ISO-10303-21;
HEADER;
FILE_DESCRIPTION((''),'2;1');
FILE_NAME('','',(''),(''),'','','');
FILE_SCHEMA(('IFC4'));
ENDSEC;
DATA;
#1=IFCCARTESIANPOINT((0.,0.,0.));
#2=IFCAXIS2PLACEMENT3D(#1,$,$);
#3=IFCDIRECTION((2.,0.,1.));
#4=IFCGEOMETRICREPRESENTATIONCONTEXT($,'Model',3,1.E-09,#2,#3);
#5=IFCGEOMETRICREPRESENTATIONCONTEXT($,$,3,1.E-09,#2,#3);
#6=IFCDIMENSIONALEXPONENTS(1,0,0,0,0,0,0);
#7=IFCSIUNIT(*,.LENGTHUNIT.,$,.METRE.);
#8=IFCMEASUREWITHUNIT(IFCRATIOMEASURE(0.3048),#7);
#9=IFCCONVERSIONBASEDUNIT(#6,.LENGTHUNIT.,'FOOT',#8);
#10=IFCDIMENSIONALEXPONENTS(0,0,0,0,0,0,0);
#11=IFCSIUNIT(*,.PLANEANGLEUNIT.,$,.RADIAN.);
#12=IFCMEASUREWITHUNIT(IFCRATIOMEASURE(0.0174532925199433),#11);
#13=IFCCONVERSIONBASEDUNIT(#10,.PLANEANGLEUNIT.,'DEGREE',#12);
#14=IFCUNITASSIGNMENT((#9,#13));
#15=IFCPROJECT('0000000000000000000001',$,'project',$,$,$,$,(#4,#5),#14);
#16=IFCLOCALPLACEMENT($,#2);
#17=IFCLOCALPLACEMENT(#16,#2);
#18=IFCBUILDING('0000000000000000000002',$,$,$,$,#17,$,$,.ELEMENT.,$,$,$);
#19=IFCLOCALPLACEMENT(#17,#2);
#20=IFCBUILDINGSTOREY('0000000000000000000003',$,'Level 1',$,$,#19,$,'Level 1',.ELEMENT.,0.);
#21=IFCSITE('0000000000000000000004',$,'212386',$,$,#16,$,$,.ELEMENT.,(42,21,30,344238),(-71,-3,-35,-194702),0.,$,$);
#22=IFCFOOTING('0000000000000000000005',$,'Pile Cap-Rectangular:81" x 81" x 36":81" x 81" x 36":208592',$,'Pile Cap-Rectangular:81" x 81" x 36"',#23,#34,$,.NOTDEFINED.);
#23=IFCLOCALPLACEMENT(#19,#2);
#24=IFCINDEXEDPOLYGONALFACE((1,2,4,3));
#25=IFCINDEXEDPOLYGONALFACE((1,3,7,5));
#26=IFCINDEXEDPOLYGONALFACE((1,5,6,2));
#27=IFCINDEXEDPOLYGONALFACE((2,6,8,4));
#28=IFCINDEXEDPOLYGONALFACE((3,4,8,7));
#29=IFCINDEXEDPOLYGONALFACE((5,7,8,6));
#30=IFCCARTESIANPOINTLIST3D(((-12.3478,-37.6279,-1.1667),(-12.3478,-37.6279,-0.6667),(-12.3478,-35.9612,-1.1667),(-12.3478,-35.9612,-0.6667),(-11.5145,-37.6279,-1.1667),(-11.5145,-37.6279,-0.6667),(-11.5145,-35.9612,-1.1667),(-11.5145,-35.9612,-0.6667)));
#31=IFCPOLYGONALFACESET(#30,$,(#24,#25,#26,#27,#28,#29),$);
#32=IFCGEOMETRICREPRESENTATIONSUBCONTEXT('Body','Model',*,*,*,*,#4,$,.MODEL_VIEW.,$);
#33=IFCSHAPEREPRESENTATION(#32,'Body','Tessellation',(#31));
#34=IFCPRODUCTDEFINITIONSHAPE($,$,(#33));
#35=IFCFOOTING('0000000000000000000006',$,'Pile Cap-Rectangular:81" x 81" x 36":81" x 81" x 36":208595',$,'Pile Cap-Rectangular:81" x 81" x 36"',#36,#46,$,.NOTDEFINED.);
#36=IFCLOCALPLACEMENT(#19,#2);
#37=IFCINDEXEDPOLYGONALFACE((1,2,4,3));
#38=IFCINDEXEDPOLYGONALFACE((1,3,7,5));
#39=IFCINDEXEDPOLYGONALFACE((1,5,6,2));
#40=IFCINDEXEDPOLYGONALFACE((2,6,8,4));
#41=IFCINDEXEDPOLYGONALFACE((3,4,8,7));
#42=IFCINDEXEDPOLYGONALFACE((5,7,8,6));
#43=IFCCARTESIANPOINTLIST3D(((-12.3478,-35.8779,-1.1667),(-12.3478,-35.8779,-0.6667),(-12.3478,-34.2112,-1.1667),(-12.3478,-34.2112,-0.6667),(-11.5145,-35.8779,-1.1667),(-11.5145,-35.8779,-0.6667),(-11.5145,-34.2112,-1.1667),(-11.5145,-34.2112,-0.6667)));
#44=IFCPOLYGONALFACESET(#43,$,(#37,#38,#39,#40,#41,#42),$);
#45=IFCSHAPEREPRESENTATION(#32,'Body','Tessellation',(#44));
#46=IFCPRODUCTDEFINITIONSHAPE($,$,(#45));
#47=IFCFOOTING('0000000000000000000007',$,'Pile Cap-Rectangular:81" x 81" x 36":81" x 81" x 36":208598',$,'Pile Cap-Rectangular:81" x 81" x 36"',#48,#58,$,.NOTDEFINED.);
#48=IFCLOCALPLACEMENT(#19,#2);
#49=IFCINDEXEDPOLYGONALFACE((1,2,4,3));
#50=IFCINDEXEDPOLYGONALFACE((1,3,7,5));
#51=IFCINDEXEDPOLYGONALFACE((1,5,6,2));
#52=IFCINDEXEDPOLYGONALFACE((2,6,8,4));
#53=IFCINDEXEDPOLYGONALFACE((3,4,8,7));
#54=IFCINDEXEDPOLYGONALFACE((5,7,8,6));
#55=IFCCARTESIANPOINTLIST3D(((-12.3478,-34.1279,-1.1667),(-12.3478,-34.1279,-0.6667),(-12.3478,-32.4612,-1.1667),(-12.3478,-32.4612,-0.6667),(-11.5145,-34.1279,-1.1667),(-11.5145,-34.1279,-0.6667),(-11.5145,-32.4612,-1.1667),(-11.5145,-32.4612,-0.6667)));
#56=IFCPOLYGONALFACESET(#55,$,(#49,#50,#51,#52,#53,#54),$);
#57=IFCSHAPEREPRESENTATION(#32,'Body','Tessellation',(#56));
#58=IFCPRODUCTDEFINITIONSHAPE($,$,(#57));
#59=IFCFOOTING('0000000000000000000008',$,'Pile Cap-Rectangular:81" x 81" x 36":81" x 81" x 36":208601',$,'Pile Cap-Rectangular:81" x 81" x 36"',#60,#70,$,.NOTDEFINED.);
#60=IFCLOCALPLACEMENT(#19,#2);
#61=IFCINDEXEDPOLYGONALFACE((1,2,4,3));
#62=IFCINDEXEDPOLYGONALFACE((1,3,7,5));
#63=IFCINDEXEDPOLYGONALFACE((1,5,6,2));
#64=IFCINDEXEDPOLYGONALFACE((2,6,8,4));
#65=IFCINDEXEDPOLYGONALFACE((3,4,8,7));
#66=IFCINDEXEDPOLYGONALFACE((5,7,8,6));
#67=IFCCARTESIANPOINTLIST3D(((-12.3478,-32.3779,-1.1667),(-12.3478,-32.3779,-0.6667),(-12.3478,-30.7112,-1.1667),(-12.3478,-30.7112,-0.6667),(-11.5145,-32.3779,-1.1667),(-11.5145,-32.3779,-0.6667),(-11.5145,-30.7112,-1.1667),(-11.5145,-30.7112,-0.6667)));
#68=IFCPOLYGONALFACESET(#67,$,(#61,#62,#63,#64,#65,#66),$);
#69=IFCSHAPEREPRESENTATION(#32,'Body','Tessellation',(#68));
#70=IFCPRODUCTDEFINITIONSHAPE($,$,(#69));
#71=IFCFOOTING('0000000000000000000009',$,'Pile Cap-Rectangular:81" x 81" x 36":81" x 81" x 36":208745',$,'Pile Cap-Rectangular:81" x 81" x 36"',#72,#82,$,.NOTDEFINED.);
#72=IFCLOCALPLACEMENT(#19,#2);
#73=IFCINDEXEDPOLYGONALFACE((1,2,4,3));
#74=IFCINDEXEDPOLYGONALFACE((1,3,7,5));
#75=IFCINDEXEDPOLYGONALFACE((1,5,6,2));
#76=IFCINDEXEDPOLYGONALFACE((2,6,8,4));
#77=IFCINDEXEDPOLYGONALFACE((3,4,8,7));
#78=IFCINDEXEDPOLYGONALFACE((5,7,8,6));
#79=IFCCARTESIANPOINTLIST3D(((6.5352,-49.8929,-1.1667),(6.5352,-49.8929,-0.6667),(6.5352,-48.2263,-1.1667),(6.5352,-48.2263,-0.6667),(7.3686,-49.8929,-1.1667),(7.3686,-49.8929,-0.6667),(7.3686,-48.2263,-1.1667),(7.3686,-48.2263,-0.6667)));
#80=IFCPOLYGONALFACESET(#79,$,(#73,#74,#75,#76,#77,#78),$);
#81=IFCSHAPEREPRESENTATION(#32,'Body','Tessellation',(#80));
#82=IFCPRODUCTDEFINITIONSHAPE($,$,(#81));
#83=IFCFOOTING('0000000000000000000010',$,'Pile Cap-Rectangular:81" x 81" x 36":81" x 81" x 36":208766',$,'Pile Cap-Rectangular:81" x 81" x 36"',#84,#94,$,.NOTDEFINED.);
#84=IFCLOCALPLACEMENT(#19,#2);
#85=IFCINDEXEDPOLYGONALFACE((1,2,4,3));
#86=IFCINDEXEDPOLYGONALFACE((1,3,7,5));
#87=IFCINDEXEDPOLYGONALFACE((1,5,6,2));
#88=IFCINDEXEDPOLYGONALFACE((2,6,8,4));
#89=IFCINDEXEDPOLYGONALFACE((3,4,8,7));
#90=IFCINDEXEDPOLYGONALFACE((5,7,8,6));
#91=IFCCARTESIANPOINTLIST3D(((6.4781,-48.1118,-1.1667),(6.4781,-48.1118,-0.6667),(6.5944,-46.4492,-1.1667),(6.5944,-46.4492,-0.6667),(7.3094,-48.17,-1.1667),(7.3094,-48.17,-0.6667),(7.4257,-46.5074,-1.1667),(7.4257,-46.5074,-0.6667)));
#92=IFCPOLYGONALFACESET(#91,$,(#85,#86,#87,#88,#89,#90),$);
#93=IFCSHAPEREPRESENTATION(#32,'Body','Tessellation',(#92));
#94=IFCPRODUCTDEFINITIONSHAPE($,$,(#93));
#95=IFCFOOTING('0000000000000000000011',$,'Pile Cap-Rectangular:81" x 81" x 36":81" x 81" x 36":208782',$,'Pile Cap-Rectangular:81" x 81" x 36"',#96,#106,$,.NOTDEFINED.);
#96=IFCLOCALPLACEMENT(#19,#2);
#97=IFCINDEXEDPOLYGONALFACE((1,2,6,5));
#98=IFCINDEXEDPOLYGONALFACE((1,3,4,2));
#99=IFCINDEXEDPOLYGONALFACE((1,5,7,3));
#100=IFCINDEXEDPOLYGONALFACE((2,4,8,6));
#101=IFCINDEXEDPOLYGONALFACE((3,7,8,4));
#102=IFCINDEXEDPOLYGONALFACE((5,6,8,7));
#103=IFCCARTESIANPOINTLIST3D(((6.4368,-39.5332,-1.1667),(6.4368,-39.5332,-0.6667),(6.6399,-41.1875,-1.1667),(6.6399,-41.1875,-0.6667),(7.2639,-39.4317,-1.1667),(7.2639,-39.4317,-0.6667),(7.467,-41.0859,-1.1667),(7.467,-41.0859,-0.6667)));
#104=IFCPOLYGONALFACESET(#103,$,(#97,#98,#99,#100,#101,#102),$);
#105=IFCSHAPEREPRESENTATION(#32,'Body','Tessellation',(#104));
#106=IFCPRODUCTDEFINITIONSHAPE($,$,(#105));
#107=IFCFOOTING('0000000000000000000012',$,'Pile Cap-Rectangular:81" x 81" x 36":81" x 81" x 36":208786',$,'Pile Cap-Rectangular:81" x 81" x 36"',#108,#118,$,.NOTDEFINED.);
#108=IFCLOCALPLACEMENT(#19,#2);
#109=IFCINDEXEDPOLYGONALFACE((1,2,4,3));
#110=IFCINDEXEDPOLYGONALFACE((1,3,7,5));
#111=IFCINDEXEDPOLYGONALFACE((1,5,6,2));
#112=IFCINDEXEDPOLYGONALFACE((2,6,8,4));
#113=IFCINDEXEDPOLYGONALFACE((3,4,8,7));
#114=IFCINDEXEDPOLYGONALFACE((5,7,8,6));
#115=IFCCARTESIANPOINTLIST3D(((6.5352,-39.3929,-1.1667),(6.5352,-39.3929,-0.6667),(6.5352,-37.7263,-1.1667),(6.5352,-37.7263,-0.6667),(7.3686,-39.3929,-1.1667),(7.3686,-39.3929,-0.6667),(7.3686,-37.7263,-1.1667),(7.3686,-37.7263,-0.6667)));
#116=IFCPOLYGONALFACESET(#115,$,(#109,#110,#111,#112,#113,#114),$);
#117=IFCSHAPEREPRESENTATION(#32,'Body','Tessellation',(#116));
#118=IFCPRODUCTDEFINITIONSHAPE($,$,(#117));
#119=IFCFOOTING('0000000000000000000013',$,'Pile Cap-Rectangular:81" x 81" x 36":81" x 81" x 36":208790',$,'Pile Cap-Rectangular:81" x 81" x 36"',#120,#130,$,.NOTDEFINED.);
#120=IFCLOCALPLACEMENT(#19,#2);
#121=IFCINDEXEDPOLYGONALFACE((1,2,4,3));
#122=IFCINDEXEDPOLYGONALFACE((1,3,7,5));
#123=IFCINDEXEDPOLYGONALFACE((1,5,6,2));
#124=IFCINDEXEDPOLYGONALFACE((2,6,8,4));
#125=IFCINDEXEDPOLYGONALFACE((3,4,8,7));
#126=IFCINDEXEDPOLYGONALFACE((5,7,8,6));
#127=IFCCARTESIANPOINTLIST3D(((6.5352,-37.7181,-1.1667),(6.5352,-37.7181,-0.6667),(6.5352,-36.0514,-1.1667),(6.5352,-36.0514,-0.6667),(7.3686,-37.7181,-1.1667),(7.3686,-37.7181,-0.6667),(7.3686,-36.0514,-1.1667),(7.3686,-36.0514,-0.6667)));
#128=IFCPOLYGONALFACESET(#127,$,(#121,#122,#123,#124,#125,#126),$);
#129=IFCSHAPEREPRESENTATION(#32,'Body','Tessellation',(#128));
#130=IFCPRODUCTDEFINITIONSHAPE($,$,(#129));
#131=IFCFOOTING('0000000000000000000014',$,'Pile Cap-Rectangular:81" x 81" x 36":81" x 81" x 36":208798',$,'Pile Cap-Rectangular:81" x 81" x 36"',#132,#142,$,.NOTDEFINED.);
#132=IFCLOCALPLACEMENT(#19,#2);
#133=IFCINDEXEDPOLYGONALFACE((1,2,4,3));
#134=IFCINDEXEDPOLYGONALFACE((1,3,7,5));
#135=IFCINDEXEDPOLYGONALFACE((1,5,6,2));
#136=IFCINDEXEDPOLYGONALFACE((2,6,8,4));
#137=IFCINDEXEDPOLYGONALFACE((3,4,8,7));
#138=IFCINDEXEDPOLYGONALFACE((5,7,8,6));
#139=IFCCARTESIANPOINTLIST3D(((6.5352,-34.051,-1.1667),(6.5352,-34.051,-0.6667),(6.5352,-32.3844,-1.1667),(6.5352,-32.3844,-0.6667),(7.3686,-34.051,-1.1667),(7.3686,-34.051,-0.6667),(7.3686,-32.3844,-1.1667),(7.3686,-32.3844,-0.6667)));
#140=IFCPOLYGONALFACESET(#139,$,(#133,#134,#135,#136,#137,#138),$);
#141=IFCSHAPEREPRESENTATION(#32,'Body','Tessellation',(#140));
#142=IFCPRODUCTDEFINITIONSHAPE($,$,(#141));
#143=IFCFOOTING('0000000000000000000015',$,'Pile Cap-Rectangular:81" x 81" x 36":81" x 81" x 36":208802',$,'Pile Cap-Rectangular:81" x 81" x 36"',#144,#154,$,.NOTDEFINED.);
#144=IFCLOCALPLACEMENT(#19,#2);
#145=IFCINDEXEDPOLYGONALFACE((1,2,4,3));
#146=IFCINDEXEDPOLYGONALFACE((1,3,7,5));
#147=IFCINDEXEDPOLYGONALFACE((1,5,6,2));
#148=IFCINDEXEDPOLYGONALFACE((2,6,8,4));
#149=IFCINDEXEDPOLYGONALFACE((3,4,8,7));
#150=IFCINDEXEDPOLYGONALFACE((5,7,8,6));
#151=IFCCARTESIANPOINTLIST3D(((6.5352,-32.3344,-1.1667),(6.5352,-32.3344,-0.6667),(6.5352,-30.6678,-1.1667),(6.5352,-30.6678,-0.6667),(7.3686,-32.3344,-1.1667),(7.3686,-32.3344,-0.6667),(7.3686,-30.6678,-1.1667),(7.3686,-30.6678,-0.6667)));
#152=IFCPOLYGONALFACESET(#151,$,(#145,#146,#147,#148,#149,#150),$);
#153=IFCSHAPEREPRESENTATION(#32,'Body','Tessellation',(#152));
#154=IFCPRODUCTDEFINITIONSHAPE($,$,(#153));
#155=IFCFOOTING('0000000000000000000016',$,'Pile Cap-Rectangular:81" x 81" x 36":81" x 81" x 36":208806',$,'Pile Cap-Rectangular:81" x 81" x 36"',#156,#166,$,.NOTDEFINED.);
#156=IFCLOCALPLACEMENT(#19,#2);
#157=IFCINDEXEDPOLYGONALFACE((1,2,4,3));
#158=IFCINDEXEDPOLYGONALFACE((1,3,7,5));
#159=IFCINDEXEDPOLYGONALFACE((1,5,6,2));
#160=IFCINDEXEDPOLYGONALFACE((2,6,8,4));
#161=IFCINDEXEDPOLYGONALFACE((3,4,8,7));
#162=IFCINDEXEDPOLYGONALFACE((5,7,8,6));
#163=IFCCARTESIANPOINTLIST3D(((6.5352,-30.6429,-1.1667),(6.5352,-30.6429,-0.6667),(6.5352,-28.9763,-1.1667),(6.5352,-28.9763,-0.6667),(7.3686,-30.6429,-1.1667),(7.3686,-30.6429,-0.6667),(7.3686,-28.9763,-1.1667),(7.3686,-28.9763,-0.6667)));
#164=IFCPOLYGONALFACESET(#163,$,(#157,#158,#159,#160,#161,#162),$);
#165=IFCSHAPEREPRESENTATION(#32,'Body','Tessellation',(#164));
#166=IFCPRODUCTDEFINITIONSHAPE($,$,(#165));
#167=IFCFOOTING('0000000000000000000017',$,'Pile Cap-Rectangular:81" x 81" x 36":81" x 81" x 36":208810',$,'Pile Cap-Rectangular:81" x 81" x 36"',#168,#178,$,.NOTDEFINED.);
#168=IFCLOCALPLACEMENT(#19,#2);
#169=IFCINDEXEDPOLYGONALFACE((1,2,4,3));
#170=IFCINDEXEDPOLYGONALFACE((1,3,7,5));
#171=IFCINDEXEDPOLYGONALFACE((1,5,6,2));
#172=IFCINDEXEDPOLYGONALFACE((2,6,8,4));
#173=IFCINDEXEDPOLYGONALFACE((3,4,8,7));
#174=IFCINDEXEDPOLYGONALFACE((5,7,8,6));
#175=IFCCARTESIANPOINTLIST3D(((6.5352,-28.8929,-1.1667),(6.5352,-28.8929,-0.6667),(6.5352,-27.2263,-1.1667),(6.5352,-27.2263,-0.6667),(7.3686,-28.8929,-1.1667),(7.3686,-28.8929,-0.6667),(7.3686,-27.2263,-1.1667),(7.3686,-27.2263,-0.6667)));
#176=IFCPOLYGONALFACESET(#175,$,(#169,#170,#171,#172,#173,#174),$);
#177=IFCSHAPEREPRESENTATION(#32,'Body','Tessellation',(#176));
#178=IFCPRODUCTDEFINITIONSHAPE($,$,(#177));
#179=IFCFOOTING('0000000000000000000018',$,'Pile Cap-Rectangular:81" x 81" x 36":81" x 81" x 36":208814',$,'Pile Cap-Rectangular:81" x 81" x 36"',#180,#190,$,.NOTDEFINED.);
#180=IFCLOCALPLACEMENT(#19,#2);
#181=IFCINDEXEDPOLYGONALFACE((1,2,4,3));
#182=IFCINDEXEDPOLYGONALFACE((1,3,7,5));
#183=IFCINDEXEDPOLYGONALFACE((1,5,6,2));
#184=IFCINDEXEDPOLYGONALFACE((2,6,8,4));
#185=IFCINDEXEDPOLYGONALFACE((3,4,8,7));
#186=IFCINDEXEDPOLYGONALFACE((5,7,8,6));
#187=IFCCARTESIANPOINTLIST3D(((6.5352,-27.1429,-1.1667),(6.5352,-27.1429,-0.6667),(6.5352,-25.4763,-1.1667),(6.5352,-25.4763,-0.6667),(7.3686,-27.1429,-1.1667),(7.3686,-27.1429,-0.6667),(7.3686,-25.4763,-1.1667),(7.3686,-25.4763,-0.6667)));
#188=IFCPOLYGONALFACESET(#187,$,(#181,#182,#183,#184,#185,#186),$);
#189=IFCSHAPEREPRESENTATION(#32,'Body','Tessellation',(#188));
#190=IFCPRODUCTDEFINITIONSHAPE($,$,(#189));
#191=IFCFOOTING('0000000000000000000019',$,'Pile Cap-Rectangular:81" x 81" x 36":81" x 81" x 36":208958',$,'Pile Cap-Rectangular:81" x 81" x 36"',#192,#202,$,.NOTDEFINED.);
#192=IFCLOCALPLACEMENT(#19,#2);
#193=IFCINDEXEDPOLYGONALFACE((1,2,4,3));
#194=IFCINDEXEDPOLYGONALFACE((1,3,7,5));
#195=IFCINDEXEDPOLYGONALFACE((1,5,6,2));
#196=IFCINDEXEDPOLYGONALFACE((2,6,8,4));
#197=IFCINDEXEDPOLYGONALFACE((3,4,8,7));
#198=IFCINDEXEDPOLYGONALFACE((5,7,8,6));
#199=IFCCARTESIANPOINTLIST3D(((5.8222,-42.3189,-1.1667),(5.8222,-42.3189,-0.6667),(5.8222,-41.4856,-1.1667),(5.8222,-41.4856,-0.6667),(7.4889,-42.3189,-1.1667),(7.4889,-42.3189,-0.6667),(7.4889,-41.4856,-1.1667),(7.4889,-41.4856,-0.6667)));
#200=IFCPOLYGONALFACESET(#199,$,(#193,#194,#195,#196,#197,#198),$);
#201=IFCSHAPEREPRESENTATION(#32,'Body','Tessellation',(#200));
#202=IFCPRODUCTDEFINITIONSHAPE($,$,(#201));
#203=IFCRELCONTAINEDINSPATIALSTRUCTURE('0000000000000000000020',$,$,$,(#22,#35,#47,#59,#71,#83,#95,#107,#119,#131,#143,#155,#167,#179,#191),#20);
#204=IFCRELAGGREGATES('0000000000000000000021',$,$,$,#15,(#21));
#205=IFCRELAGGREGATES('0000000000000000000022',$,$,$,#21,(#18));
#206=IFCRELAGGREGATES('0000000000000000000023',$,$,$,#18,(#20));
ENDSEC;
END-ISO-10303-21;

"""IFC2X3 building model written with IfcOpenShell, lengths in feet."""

from ifc_helpers import new_model, entity, si_unit, converted_unit, direction, frame, frame_2d, origin, origin_2d_with_axis, place, context, subcontext, project, spatial, rectangle, extrude, element, save


model = new_model("IFC2X3")

# Units and contexts
model_context = context("Model", 3, precision=1e-09, world=origin(), true_north=direction((2.0, 0.0, 1.0)))
context_of_model = context(None, 3, precision=1e-09, world=origin(), true_north=direction((2.0, 0.0, 1.0)))
body_context = subcontext(model_context, "Body", "Model", "MODEL_VIEW")
ifc_project = project(units=[converted_unit("LENGTHUNIT", "FOOT", entity("IfcRatioMeasure", 0.3048), si_unit("LENGTHUNIT", "METRE"), dimensions=[1, 0, 0, 0, 0, 0, 0]), converted_unit("PLANEANGLEUNIT", "DEGREE", entity("IfcRatioMeasure", 0.0174532925199433), si_unit("PLANEANGLEUNIT", "RADIAN"), dimensions=[0, 0, 0, 0, 0, 0, 0])], contexts=[model_context, context_of_model])

# Site, building, storey
site_placement = place(None, origin())
site = spatial("IfcSite", under=ifc_project, at=site_placement, Name="212386", CompositionType="ELEMENT", RefLatitude=(42, 21, 30, 344238), RefLongitude=(-71, -3, -35, -194702), RefElevation=0.0)
building_placement = place(site_placement, origin())
building = spatial("IfcBuilding", under=site, at=building_placement, CompositionType="ELEMENT")
storey_placement = place(building_placement, origin())
storey = spatial("IfcBuildingStorey", under=building, at=storey_placement, Name="Level 1", LongName="Level 1", CompositionType="ELEMENT", Elevation=0.0)

# Footings
footing_1_placement = place(storey_placement, origin())
element("IfcFooting", 1, at=footing_1_placement, inside=storey, Name="Pile Cap-Rectangular:81\" x 81\" x 36\":81\" x 81\" x 36\":208592", ObjectType="Pile Cap-Rectangular:81\" x 81\" x 36\"", PredefinedType="NOTDEFINED", context=body_context, shape_type="SweptSolid", body=[
    extrude(rectangle(XDim=0.8333, YDim=1.6667, at=frame_2d((0.0, 0.0), x_axis=(1.0, 0.0))), frame((-11.9311, -36.7946, -1.1667), z_axis=(0.0, 0.0, 1.0), x_axis=(-1.0, 0.0, 0.0)), (0.0, 0.0, 1.0), 0.5),
])
footing_2_placement = place(storey_placement, origin())
element("IfcFooting", 2, at=footing_2_placement, inside=storey, Name="Pile Cap-Rectangular:81\" x 81\" x 36\":81\" x 81\" x 36\":208595", ObjectType="Pile Cap-Rectangular:81\" x 81\" x 36\"", PredefinedType="NOTDEFINED", context=body_context, shape_type="SweptSolid", body=[
    extrude(rectangle(XDim=0.8333, YDim=1.6667, at=frame_2d((0.0, 0.0), x_axis=(1.0, 0.0))), frame((-11.9311, -35.0446, -1.1667), z_axis=(0.0, 0.0, 1.0), x_axis=(-1.0, 0.0, 0.0)), (0.0, 0.0, 1.0), 0.5),
])
footing_3_placement = place(storey_placement, origin())
element("IfcFooting", 3, at=footing_3_placement, inside=storey, Name="Pile Cap-Rectangular:81\" x 81\" x 36\":81\" x 81\" x 36\":208598", ObjectType="Pile Cap-Rectangular:81\" x 81\" x 36\"", PredefinedType="NOTDEFINED", context=body_context, shape_type="SweptSolid", body=[
    extrude(rectangle(XDim=0.8333, YDim=1.6667, at=frame_2d((0.0, 0.0), x_axis=(1.0, 0.0))), frame((-11.9311, -33.2946, -1.1667), z_axis=(0.0, 0.0, 1.0), x_axis=(-1.0, 0.0, 0.0)), (0.0, 0.0, 1.0), 0.5),
])
footing_4_placement = place(storey_placement, origin())
element("IfcFooting", 4, at=footing_4_placement, inside=storey, Name="Pile Cap-Rectangular:81\" x 81\" x 36\":81\" x 81\" x 36\":208601", ObjectType="Pile Cap-Rectangular:81\" x 81\" x 36\"", PredefinedType="NOTDEFINED", context=body_context, shape_type="SweptSolid", body=[
    extrude(rectangle(XDim=0.8333, YDim=1.6667, at=origin_2d_with_axis()), frame((-11.9311, -31.5446, -1.1667), z_axis=(0.0, 0.0, 1.0), x_axis=(-1.0, 0.0, 0.0)), (0.0, 0.0, 1.0), 0.5),
])
footing_5_placement = place(storey_placement, origin())
element("IfcFooting", 5, at=footing_5_placement, inside=storey, Name="Pile Cap-Rectangular:81\" x 81\" x 36\":81\" x 81\" x 36\":208745", ObjectType="Pile Cap-Rectangular:81\" x 81\" x 36\"", PredefinedType="NOTDEFINED", context=body_context, shape_type="SweptSolid", body=[
    extrude(rectangle(XDim=0.8333, YDim=1.6667, at=frame_2d((0.0, 0.0), x_axis=(1.0, 0.0))), frame((6.9519, -49.0596, -1.1667), z_axis=(0.0, 0.0, 1.0), x_axis=(-1.0, 0.0, 0.0)), (0.0, 0.0, 1.0), 0.5),
])
footing_6_placement = place(storey_placement, origin())
element("IfcFooting", 6, at=footing_6_placement, inside=storey, Name="Pile Cap-Rectangular:81\" x 81\" x 36\":81\" x 81\" x 36\":208766", ObjectType="Pile Cap-Rectangular:81\" x 81\" x 36\"", PredefinedType="NOTDEFINED", context=body_context, shape_type="SweptSolid", body=[
    extrude(rectangle(XDim=0.8333, YDim=1.6667, at=frame_2d((0.0, 0.0), x_axis=(1.0, 0.0))), frame((6.9519, -47.3096, -1.1667), z_axis=(0.0, 0.0, 1.0), x_axis=(-0.997564, 0.069756, 0.0)), (0.0, 0.0, 1.0), 0.5),
])
footing_7_placement = place(storey_placement, origin())
element("IfcFooting", 7, at=footing_7_placement, inside=storey, Name="Pile Cap-Rectangular:81\" x 81\" x 36\":81\" x 81\" x 36\":208782", ObjectType="Pile Cap-Rectangular:81\" x 81\" x 36\"", PredefinedType="NOTDEFINED", context=body_context, shape_type="SweptSolid", body=[
    extrude(rectangle(XDim=0.8333, YDim=1.6667, at=frame_2d((0.0, 0.0), x_axis=(1.0, 0.0))), frame((6.9519, -40.3096, -1.1667), z_axis=(0.0, 0.0, 1.0), x_axis=(-0.992546, -0.121869, 0.0)), (0.0, 0.0, 1.0), 0.5),
])
footing_8_placement = place(storey_placement, origin())
element("IfcFooting", 8, at=footing_8_placement, inside=storey, Name="Pile Cap-Rectangular:81\" x 81\" x 36\":81\" x 81\" x 36\":208786", ObjectType="Pile Cap-Rectangular:81\" x 81\" x 36\"", PredefinedType="NOTDEFINED", context=body_context, shape_type="SweptSolid", body=[
    extrude(rectangle(XDim=0.8333, YDim=1.6667, at=frame_2d((0.0, 0.0), x_axis=(1.0, 0.0))), frame((6.9519, -38.5596, -1.1667), z_axis=(0.0, 0.0, 1.0), x_axis=(-1.0, 0.0, 0.0)), (0.0, 0.0, 1.0), 0.5),
])
footing_9_placement = place(storey_placement, origin())
element("IfcFooting", 9, at=footing_9_placement, inside=storey, Name="Pile Cap-Rectangular:81\" x 81\" x 36\":81\" x 81\" x 36\":208790", ObjectType="Pile Cap-Rectangular:81\" x 81\" x 36\"", PredefinedType="NOTDEFINED", context=body_context, shape_type="SweptSolid", body=[
    extrude(rectangle(XDim=0.8333, YDim=1.6667, at=frame_2d((0.0, 0.0), x_axis=(1.0, 0.0))), frame((6.9519, -36.8848, -1.1667), z_axis=(0.0, 0.0, 1.0), x_axis=(-1.0, 0.0, 0.0)), (0.0, 0.0, 1.0), 0.5),
])
footing_10_placement = place(storey_placement, origin())
element("IfcFooting", 10, at=footing_10_placement, inside=storey, Name="Pile Cap-Rectangular:81\" x 81\" x 36\":81\" x 81\" x 36\":208798", ObjectType="Pile Cap-Rectangular:81\" x 81\" x 36\"", PredefinedType="NOTDEFINED", context=body_context, shape_type="SweptSolid", body=[
    extrude(rectangle(XDim=0.8333, YDim=1.6667, at=frame_2d((0.0, 0.0), x_axis=(1.0, 0.0))), frame((6.9519, -33.2177, -1.1667), z_axis=(0.0, 0.0, 1.0), x_axis=(-1.0, 0.0, 0.0)), (0.0, 0.0, 1.0), 0.5),
])
footing_11_placement = place(storey_placement, origin())
element("IfcFooting", 11, at=footing_11_placement, inside=storey, Name="Pile Cap-Rectangular:81\" x 81\" x 36\":81\" x 81\" x 36\":208802", ObjectType="Pile Cap-Rectangular:81\" x 81\" x 36\"", PredefinedType="NOTDEFINED", context=body_context, shape_type="SweptSolid", body=[
    extrude(rectangle(XDim=0.8333, YDim=1.6667, at=frame_2d((0.0, 0.0), x_axis=(1.0, 0.0))), frame((6.9519, -31.5011, -1.1667), z_axis=(0.0, 0.0, 1.0), x_axis=(-1.0, 0.0, 0.0)), (0.0, 0.0, 1.0), 0.5),
])
footing_12_placement = place(storey_placement, origin())
element("IfcFooting", 12, at=footing_12_placement, inside=storey, Name="Pile Cap-Rectangular:81\" x 81\" x 36\":81\" x 81\" x 36\":208806", ObjectType="Pile Cap-Rectangular:81\" x 81\" x 36\"", PredefinedType="NOTDEFINED", context=body_context, shape_type="SweptSolid", body=[
    extrude(rectangle(XDim=0.8333, YDim=1.6667, at=frame_2d((0.0, 0.0), x_axis=(1.0, 0.0))), frame((6.9519, -29.8096, -1.1667), z_axis=(0.0, 0.0, 1.0), x_axis=(-1.0, 0.0, 0.0)), (0.0, 0.0, 1.0), 0.5),
])
footing_13_placement = place(storey_placement, origin())
element("IfcFooting", 13, at=footing_13_placement, inside=storey, Name="Pile Cap-Rectangular:81\" x 81\" x 36\":81\" x 81\" x 36\":208810", ObjectType="Pile Cap-Rectangular:81\" x 81\" x 36\"", PredefinedType="NOTDEFINED", context=body_context, shape_type="SweptSolid", body=[
    extrude(rectangle(XDim=0.8333, YDim=1.6667, at=frame_2d((0.0, 0.0), x_axis=(1.0, 0.0))), frame((6.9519, -28.0596, -1.1667), z_axis=(0.0, 0.0, 1.0), x_axis=(-1.0, 0.0, 0.0)), (0.0, 0.0, 1.0), 0.5),
])
footing_14_placement = place(storey_placement, origin())
element("IfcFooting", 14, at=footing_14_placement, inside=storey, Name="Pile Cap-Rectangular:81\" x 81\" x 36\":81\" x 81\" x 36\":208814", ObjectType="Pile Cap-Rectangular:81\" x 81\" x 36\"", PredefinedType="NOTDEFINED", context=body_context, shape_type="SweptSolid", body=[
    extrude(rectangle(XDim=0.8333, YDim=1.6667, at=frame_2d((0.0, 0.0), x_axis=(1.0, 0.0))), frame((6.9519, -26.3096, -1.1667), z_axis=(0.0, 0.0, 1.0), x_axis=(-1.0, 0.0, 0.0)), (0.0, 0.0, 1.0), 0.5),
])
footing_15_placement = place(storey_placement, origin())
element("IfcFooting", 15, at=footing_15_placement, inside=storey, Name="Pile Cap-Rectangular:81\" x 81\" x 36\":81\" x 81\" x 36\":208958", ObjectType="Pile Cap-Rectangular:81\" x 81\" x 36\"", PredefinedType="NOTDEFINED", context=body_context, shape_type="SweptSolid", body=[
    extrude(rectangle(XDim=0.8333, YDim=1.6667, at=frame_2d((0.0, 0.0), x_axis=(1.0, 0.0))), frame((6.6556, -41.9022, -1.1667), z_axis=(0.0, 0.0, 1.0), x_axis=(0.0, 1.0, 0.0)), (0.0, 0.0, 1.0), 0.5),
])

save(model, "model.ifc")
